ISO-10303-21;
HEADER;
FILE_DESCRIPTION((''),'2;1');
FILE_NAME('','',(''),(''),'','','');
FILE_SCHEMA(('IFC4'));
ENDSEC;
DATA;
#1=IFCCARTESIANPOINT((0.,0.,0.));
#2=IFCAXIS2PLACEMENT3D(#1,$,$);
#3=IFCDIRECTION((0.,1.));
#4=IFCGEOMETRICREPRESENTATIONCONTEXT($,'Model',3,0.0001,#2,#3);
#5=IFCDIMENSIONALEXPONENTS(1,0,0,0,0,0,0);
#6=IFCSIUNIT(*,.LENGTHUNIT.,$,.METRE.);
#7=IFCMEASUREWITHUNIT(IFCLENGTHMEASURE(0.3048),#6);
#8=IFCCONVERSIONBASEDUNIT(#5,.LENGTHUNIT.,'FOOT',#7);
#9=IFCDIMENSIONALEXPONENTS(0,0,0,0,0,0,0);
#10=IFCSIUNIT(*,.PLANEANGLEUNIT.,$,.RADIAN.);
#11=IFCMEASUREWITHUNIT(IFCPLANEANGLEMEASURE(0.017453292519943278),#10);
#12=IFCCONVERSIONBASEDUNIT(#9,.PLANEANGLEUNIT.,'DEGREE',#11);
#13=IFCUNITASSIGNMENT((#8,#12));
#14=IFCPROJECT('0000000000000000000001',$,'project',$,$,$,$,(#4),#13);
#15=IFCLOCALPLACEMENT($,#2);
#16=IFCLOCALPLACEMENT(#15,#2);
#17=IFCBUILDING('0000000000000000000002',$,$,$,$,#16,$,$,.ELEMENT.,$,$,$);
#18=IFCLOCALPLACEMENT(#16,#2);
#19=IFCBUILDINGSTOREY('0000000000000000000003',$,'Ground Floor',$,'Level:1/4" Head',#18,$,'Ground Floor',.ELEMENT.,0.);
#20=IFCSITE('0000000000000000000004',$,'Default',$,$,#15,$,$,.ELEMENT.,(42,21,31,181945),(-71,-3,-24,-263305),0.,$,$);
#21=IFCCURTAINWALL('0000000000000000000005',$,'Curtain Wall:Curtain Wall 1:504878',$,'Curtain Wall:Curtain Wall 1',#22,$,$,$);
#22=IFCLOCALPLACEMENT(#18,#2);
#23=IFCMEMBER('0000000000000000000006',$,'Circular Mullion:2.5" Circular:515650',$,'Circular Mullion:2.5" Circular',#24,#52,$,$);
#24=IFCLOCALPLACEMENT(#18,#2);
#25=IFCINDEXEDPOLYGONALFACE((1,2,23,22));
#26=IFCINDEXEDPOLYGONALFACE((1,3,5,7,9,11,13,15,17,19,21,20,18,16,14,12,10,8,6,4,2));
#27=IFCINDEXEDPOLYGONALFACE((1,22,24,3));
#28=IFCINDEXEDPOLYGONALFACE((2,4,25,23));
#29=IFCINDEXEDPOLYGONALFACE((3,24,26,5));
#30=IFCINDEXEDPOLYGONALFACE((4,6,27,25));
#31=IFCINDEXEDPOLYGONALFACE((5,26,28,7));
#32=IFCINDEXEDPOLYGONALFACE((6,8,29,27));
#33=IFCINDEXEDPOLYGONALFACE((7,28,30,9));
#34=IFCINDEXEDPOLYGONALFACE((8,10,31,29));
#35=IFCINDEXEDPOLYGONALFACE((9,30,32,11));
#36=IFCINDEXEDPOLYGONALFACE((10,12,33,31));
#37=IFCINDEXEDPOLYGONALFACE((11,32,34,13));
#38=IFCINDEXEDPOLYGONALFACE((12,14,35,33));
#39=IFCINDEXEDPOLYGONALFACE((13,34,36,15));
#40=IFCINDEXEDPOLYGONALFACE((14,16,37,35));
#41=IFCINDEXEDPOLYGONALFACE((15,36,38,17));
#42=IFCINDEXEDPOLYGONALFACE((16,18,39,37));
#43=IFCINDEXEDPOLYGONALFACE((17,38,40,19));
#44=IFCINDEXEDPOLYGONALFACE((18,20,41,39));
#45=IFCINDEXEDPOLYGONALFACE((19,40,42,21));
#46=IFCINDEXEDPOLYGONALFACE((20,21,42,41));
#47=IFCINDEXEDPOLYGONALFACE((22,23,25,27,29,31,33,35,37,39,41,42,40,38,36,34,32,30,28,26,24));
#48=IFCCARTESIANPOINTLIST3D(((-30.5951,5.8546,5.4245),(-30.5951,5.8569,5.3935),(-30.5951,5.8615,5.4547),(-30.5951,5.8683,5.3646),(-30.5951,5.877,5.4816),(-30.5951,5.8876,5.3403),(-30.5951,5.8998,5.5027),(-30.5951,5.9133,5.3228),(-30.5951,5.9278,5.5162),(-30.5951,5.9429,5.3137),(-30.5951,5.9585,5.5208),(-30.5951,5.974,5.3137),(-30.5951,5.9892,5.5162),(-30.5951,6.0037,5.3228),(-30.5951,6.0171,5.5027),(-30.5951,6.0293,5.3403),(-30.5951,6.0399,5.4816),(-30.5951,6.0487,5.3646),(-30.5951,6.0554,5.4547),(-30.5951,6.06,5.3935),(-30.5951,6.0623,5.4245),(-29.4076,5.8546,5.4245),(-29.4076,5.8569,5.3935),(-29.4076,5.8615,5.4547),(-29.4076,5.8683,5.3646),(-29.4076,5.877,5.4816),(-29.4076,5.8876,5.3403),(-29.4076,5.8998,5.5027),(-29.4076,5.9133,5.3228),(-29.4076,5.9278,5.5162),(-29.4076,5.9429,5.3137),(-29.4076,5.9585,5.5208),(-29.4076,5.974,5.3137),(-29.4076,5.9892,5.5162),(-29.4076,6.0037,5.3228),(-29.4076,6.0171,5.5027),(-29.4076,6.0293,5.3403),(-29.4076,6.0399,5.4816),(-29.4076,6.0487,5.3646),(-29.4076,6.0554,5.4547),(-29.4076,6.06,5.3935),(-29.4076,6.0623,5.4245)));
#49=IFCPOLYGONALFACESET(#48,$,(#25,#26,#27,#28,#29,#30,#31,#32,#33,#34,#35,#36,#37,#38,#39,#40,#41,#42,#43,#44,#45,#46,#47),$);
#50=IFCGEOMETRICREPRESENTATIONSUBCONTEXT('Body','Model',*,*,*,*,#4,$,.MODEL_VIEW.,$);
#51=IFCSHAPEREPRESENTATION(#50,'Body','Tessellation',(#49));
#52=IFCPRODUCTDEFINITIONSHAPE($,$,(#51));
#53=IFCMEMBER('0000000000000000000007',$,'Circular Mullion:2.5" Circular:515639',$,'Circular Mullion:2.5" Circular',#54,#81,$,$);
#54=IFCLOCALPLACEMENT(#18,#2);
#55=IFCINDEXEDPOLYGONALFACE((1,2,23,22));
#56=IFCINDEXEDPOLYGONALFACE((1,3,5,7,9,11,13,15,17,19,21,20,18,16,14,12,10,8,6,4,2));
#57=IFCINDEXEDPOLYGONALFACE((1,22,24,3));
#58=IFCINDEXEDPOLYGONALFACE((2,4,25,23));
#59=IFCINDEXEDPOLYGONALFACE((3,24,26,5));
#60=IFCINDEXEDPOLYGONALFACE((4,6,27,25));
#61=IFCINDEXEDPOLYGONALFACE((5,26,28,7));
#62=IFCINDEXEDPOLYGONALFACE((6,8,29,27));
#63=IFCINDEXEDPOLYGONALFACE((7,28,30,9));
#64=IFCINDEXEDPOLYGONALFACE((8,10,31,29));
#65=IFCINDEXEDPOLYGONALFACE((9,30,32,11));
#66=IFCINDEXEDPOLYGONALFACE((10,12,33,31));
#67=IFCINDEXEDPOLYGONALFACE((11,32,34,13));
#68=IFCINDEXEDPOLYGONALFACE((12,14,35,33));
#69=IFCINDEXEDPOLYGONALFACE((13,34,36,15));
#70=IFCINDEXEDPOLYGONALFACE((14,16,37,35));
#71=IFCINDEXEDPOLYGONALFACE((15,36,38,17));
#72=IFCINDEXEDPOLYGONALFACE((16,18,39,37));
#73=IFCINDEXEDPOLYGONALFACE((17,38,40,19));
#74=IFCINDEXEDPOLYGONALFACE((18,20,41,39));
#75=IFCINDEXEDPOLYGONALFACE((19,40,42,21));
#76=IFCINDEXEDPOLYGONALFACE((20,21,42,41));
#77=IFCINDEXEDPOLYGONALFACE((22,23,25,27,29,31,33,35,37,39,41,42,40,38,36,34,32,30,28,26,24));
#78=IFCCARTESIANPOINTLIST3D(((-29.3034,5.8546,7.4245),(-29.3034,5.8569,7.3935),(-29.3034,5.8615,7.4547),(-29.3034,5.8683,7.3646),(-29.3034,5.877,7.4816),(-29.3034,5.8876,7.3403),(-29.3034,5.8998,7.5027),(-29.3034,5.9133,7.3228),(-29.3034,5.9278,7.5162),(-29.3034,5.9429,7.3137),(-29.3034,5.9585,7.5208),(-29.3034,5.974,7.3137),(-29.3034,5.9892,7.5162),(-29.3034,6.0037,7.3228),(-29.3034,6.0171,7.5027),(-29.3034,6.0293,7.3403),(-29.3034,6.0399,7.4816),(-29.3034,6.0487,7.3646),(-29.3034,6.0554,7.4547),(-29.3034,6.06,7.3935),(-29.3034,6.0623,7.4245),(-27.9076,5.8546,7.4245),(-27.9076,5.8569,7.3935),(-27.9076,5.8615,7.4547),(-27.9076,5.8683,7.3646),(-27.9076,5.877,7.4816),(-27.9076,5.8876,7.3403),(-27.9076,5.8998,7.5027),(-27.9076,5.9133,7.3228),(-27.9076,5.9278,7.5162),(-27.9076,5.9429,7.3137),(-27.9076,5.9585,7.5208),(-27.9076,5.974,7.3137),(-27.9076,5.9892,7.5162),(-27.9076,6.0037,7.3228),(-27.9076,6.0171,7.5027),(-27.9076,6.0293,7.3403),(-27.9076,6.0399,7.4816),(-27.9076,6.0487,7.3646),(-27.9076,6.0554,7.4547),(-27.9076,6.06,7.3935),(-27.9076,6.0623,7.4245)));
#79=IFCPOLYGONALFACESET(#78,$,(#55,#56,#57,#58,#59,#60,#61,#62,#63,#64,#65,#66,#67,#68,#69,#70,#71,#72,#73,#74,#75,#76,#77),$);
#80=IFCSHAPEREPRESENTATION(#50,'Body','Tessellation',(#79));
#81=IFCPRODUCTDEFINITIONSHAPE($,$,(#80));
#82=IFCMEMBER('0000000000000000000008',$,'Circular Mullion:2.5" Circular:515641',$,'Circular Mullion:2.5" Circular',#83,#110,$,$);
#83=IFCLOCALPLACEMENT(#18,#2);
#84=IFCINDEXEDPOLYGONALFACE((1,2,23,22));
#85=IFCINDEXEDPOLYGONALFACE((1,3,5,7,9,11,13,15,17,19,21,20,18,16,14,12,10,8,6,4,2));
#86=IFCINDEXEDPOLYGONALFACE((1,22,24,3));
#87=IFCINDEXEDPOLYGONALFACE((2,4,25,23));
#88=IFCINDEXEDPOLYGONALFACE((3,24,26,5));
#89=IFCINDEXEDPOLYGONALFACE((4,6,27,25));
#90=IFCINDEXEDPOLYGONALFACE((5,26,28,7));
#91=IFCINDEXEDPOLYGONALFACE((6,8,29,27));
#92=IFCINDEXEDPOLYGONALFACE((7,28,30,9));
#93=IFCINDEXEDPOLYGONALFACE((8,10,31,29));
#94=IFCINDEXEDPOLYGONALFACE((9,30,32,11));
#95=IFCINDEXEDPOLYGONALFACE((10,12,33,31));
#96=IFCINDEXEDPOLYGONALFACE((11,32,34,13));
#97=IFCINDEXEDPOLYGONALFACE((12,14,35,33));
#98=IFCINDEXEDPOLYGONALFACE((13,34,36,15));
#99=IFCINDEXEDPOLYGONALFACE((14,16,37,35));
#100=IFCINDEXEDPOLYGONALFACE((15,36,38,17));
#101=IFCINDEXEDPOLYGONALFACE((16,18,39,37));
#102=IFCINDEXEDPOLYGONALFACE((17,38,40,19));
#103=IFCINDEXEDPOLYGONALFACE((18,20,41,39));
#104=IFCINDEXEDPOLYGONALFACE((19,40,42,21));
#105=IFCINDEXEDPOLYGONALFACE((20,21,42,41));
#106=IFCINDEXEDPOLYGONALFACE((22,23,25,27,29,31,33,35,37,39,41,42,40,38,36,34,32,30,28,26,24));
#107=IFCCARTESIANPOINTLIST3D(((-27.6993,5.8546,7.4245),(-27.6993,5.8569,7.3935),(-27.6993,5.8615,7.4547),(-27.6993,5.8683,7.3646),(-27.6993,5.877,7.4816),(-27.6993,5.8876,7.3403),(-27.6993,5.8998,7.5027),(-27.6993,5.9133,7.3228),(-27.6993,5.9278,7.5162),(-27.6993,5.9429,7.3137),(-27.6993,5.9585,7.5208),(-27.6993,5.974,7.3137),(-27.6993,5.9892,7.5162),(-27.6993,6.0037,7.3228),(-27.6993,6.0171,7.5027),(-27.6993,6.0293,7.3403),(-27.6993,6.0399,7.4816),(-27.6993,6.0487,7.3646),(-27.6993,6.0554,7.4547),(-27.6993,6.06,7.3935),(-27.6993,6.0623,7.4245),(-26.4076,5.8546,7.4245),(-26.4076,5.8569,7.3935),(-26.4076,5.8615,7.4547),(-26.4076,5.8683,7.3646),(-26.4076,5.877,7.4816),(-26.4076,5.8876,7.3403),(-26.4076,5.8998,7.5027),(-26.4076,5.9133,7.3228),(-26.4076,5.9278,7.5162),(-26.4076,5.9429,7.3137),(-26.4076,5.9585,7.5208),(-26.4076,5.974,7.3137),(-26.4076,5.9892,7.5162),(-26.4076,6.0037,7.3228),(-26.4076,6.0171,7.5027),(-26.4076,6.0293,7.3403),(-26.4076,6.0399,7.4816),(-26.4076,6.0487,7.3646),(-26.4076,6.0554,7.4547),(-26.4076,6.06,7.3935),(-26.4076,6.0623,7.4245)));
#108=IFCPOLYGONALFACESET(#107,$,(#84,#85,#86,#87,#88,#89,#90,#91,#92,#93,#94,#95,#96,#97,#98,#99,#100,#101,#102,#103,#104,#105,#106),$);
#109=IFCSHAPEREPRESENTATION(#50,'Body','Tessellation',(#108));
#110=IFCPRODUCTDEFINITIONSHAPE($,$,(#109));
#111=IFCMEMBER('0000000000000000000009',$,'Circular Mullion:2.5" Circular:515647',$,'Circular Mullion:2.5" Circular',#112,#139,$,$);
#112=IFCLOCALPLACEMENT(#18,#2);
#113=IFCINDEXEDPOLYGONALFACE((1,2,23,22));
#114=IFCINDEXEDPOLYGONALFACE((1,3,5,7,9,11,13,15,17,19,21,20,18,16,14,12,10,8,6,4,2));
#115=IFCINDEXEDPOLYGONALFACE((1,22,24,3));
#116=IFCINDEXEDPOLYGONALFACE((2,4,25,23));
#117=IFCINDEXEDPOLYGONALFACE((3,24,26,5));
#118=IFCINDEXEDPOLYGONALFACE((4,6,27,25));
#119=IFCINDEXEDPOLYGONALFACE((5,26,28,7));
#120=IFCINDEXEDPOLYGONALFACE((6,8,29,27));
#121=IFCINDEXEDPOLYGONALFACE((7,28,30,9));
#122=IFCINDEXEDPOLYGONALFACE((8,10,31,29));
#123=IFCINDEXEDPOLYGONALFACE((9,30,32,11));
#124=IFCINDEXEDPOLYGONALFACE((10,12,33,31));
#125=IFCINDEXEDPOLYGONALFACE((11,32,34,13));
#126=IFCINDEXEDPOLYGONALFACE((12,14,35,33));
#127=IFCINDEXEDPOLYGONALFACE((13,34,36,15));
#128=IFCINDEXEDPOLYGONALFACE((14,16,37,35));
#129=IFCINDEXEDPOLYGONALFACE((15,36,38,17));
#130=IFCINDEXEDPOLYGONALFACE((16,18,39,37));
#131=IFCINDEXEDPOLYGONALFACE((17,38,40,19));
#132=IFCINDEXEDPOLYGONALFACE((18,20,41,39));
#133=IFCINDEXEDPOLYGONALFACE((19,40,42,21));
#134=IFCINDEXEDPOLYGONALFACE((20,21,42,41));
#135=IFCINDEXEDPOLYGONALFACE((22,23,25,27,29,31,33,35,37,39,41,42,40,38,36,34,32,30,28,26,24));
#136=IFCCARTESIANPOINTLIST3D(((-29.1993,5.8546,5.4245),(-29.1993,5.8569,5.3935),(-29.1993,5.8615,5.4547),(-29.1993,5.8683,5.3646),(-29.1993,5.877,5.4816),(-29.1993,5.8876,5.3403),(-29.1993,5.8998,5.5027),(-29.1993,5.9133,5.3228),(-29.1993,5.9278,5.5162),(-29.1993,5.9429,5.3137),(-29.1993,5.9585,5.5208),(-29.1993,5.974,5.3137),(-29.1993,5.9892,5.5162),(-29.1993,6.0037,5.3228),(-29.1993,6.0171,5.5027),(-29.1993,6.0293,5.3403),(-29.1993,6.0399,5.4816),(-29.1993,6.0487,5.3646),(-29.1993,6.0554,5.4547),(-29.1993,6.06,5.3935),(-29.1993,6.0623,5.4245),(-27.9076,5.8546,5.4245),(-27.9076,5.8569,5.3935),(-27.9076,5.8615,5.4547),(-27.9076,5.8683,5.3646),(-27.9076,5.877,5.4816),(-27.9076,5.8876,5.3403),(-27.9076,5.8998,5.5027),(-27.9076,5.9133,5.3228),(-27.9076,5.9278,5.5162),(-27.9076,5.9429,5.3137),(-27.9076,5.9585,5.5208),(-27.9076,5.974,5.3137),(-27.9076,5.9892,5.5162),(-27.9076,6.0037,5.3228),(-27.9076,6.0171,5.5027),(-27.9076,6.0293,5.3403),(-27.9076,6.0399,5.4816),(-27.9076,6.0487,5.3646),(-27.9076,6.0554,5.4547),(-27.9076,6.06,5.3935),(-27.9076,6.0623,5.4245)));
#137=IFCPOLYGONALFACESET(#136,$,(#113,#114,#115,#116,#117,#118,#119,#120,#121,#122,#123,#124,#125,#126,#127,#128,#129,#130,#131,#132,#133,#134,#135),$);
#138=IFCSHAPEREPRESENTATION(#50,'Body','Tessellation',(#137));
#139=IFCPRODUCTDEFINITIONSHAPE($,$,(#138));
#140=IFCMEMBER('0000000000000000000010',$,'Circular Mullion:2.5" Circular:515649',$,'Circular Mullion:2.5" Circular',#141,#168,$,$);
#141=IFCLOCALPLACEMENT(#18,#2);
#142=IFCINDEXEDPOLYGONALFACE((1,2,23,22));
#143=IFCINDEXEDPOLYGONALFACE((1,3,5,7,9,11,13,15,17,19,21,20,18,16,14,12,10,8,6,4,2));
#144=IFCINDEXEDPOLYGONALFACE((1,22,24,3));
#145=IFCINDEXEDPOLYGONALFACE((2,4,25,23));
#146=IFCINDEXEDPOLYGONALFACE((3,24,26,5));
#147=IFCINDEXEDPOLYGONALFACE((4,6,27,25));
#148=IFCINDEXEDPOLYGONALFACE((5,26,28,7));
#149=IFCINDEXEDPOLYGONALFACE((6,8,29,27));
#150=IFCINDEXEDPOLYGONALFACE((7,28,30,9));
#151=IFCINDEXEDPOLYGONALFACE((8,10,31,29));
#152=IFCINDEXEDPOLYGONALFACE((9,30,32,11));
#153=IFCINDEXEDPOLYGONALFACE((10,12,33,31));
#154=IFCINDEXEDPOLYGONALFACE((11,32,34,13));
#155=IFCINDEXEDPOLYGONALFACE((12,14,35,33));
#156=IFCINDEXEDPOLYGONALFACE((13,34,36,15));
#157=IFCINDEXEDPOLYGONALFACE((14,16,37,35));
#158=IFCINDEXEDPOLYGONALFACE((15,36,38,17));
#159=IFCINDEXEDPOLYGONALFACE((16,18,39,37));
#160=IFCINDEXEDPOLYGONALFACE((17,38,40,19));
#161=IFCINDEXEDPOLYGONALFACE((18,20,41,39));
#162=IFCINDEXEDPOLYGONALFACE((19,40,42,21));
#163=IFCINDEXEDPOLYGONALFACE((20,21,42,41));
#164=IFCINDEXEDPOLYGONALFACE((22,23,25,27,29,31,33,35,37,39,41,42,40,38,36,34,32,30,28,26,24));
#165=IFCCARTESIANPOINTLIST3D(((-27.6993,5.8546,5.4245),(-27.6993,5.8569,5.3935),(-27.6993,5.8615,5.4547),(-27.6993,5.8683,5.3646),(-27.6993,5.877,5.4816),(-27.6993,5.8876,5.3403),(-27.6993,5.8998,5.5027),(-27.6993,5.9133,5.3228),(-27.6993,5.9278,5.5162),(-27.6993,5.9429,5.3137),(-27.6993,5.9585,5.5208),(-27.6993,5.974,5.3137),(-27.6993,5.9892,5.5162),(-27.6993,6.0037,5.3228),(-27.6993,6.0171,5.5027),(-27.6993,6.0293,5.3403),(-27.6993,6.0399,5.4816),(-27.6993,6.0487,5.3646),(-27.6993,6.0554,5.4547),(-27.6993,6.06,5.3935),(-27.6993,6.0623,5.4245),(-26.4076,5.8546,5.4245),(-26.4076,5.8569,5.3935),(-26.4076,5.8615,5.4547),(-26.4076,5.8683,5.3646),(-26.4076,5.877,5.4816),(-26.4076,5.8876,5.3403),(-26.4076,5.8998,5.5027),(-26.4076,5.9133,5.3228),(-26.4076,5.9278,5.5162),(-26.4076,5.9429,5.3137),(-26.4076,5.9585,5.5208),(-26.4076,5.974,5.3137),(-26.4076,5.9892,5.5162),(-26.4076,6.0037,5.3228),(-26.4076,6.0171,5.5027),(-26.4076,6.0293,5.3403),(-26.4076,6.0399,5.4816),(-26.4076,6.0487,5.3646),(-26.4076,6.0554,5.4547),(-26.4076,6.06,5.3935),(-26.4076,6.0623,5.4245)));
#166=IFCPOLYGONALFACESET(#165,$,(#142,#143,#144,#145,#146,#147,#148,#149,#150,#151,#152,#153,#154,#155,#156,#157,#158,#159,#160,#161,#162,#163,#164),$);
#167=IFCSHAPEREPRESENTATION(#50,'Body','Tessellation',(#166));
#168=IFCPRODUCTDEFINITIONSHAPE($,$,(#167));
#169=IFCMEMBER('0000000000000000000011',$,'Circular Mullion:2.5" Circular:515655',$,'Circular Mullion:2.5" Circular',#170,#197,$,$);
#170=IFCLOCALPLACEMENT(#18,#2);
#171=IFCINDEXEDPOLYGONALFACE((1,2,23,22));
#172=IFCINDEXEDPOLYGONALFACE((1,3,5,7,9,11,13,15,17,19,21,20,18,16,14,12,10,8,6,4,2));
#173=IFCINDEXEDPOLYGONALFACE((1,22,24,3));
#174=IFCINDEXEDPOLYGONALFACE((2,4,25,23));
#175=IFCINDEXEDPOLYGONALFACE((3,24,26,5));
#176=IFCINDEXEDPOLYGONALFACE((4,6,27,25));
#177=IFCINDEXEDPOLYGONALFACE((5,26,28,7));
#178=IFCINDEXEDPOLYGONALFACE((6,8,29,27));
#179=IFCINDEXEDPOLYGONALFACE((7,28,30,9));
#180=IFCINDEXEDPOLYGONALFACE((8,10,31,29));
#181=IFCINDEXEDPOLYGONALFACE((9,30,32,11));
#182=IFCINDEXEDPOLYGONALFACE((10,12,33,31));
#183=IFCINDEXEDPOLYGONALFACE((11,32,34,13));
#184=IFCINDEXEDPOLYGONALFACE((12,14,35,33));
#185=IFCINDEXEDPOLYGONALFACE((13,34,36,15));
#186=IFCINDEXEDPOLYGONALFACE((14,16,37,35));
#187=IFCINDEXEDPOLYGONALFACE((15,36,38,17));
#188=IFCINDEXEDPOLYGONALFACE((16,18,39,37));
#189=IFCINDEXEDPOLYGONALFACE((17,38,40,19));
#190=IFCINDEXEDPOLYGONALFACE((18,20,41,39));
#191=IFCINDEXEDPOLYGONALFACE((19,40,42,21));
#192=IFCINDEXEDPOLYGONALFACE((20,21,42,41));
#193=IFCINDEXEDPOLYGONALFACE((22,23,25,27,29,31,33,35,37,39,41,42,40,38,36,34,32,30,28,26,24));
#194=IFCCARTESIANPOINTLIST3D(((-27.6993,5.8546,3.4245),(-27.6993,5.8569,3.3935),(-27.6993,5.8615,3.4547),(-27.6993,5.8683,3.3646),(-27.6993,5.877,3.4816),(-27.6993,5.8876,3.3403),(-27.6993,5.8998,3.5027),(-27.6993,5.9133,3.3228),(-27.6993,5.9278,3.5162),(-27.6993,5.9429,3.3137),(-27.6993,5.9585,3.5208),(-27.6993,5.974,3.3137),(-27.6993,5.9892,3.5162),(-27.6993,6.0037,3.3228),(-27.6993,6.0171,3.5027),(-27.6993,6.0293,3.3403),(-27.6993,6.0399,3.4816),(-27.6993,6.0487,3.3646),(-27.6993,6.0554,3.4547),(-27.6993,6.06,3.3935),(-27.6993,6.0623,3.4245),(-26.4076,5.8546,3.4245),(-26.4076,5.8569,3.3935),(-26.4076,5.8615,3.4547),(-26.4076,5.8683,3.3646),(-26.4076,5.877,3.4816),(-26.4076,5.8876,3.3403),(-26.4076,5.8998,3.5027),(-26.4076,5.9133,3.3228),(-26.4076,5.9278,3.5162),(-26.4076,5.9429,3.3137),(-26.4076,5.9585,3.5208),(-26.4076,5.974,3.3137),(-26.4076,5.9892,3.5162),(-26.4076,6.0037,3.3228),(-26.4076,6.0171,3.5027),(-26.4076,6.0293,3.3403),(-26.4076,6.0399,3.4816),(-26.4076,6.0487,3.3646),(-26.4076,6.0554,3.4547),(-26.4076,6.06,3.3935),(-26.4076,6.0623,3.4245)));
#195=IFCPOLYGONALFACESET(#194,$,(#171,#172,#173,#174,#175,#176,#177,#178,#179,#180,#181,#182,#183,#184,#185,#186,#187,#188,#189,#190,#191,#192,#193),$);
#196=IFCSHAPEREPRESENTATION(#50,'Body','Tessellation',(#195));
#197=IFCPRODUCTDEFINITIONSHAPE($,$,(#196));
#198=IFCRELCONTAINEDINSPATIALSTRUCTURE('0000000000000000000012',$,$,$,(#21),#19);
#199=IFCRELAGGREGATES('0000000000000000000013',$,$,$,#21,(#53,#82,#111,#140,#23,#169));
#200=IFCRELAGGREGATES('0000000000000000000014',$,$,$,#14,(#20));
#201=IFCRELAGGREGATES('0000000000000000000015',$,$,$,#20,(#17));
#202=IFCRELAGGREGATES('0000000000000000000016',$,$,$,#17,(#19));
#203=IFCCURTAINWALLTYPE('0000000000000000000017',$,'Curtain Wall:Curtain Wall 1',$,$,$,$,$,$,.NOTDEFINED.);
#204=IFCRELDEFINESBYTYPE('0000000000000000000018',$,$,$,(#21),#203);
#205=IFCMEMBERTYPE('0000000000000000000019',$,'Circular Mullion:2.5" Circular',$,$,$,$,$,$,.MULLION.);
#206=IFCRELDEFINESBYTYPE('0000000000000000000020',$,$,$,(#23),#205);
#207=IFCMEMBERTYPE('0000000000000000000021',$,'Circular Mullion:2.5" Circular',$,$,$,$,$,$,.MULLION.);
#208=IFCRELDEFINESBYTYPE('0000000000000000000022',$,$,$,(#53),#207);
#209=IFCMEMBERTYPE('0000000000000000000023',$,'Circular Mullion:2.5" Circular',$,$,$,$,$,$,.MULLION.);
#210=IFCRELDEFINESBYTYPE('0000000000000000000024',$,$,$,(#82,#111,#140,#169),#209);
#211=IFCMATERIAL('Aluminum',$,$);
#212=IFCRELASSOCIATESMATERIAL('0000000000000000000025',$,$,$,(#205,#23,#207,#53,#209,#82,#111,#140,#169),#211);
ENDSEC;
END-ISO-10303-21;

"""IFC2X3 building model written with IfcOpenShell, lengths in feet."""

from ifc_helpers import new_model, entity, si_unit, converted_unit, direction, frame, frame_2d, origin, place, context, subcontext, project, spatial, circle, extrude, source, transform, mapped, material, type_object, type_shapes, element, aggregate, save


model = new_model("IFC2X3")

# Units and contexts
model_context = context("Model", 3, precision=0.0001, world=origin(), true_north=direction((0.0, 1.0)))
body_context = subcontext(model_context, "Body", "Model", "MODEL_VIEW")
ifc_project = project(units=[converted_unit("LENGTHUNIT", "FOOT", entity("IfcLengthMeasure", 0.3048), si_unit("LENGTHUNIT", "METRE"), dimensions=[1, 0, 0, 0, 0, 0, 0]), converted_unit("PLANEANGLEUNIT", "DEGREE", entity("IfcPlaneAngleMeasure", 0.017453292519943278), si_unit("PLANEANGLEUNIT", "RADIAN"), dimensions=[0, 0, 0, 0, 0, 0, 0])], contexts=[model_context])

# Site, building, storey
site_placement = place(None, origin())
site = spatial("IfcSite", under=ifc_project, at=site_placement, Name="Default", CompositionType="ELEMENT", RefLatitude=(42, 21, 31, 181945), RefLongitude=(-71, -3, -24, -263305), RefElevation=0.0)
building_placement = place(site_placement, origin())
building = spatial("IfcBuilding", under=site, at=building_placement, CompositionType="ELEMENT")
storey_placement = place(building_placement, origin())
storey = spatial("IfcBuildingStorey", under=building, at=storey_placement, Name="Ground Floor", ObjectType="Level:1/4\" Head", LongName="Ground Floor", CompositionType="ELEMENT", Elevation=0.0)

# Curtain wall, members
curtain_wall_type = type_object("IfcCurtainWallType", Name="Curtain Wall:Curtain Wall 1", PredefinedType="NOTDEFINED")
curtain_wall_placement = place(storey_placement, origin())
curtain_wall = element("IfcCurtainWall", 1, at=curtain_wall_placement, inside=storey, type_object=curtain_wall_type, Name="Curtain Wall:Curtain Wall 1:504878", ObjectType="Curtain Wall:Curtain Wall 1")
ifc_material_1 = material(Name="Aluminum")
member_type_1 = type_object("IfcMemberType", Name="Circular Mullion:2.5\" Circular", PredefinedType="MULLION", material=ifc_material_1)
shared_shape_1 = source(origin(), body_context, "Body", "SweptSolid", [
    extrude(circle(Radius=0.1042, at=frame_2d((0.0, 0.0), x_axis=(1.0, 0.0))), frame((0.0, 0.0, -1.1875)), (0.0, 0.0, 1.0), 1.1875),
])
type_shapes(member_type_1, [shared_shape_1])
member_1_placement = place(curtain_wall_placement, frame((-30.5951, 5.9585, 5.4167), z_axis=(-1.0, 0.0, 0.0), x_axis=(0.0, 0.0, 1.0)))
member_1 = element("IfcMember", 2, at=member_1_placement, type_object=member_type_1, material=ifc_material_1, Name="Circular Mullion:2.5\" Circular:515650", ObjectType="Circular Mullion:2.5\" Circular", context=body_context, shape_type="MappedRepresentation", body=[
    mapped(shared_shape_1, transform((0.0, 0.0, 0.0), scale=1.0)),
])
member_type_2 = type_object("IfcMemberType", Name="Circular Mullion:2.5\" Circular", PredefinedType="MULLION", material=ifc_material_1)
shared_shape_2 = source(origin(), body_context, "Body", "SweptSolid", [
    extrude(circle(Radius=0.1042, at=frame_2d((0.0, 0.0), x_axis=(1.0, 0.0))), frame((0.0, 0.0, -1.3958)), (0.0, 0.0, 1.0), 1.3958),
])
type_shapes(member_type_2, [shared_shape_2])
member_2_placement = place(curtain_wall_placement, frame((-29.3034, 5.9585, 7.4167), z_axis=(-1.0, 0.0, 0.0), x_axis=(0.0, 0.0, 1.0)))
member_2 = element("IfcMember", 3, at=member_2_placement, type_object=member_type_2, material=ifc_material_1, Name="Circular Mullion:2.5\" Circular:515639", ObjectType="Circular Mullion:2.5\" Circular", context=body_context, shape_type="MappedRepresentation", body=[
    mapped(shared_shape_2, transform((0.0, 0.0, 0.0), scale=1.0)),
])
member_type_3 = type_object("IfcMemberType", Name="Circular Mullion:2.5\" Circular", PredefinedType="MULLION", material=ifc_material_1)
shared_shape_3 = source(origin(), body_context, "Body", "SweptSolid", [
    extrude(circle(Radius=0.1042, at=frame_2d((0.0, 0.0), x_axis=(1.0, 0.0))), frame((0.0, 0.0, -1.2917)), (0.0, 0.0, 1.0), 1.2917),
])
type_shapes(member_type_3, [shared_shape_3])
member_3_placement = place(curtain_wall_placement, frame((-27.6993, 5.9585, 7.4167), z_axis=(-1.0, 0.0, 0.0), x_axis=(0.0, 0.0, 1.0)))
member_3 = element("IfcMember", 4, at=member_3_placement, type_object=member_type_3, material=ifc_material_1, Name="Circular Mullion:2.5\" Circular:515641", ObjectType="Circular Mullion:2.5\" Circular", context=body_context, shape_type="MappedRepresentation", body=[
    mapped(shared_shape_3, transform((0.0, 0.0, 0.0), scale=1.0)),
])
member_4_placement = place(curtain_wall_placement, frame((-29.1993, 5.9585, 5.4167), z_axis=(-1.0, 0.0, 0.0), x_axis=(0.0, 0.0, 1.0)))
member_4 = element("IfcMember", 5, at=member_4_placement, type_object=member_type_3, material=ifc_material_1, Name="Circular Mullion:2.5\" Circular:515647", ObjectType="Circular Mullion:2.5\" Circular", context=body_context, shape_type="MappedRepresentation", body=[
    mapped(shared_shape_3, transform((0.0, 0.0, 0.0), scale=1.0)),
])
member_5_placement = place(curtain_wall_placement, frame((-27.6993, 5.9585, 5.4167), z_axis=(-1.0, 0.0, 0.0), x_axis=(0.0, 0.0, 1.0)))
member_5 = element("IfcMember", 6, at=member_5_placement, type_object=member_type_3, material=ifc_material_1, Name="Circular Mullion:2.5\" Circular:515649", ObjectType="Circular Mullion:2.5\" Circular", context=body_context, shape_type="MappedRepresentation", body=[
    mapped(shared_shape_3, transform((0.0, 0.0, 0.0), scale=1.0)),
])
member_6_placement = place(curtain_wall_placement, frame((-27.6993, 5.9585, 3.4167), z_axis=(-1.0, 0.0, 0.0), x_axis=(0.0, 0.0, 1.0)))
member_6 = element("IfcMember", 7, at=member_6_placement, type_object=member_type_3, material=ifc_material_1, Name="Circular Mullion:2.5\" Circular:515655", ObjectType="Circular Mullion:2.5\" Circular", context=body_context, shape_type="MappedRepresentation", body=[
    mapped(shared_shape_3, transform((0.0, 0.0, 0.0), scale=1.0)),
])
aggregate(curtain_wall, [member_2, member_3, member_4, member_5, member_1, member_6])

save(model, "model.ifc")
